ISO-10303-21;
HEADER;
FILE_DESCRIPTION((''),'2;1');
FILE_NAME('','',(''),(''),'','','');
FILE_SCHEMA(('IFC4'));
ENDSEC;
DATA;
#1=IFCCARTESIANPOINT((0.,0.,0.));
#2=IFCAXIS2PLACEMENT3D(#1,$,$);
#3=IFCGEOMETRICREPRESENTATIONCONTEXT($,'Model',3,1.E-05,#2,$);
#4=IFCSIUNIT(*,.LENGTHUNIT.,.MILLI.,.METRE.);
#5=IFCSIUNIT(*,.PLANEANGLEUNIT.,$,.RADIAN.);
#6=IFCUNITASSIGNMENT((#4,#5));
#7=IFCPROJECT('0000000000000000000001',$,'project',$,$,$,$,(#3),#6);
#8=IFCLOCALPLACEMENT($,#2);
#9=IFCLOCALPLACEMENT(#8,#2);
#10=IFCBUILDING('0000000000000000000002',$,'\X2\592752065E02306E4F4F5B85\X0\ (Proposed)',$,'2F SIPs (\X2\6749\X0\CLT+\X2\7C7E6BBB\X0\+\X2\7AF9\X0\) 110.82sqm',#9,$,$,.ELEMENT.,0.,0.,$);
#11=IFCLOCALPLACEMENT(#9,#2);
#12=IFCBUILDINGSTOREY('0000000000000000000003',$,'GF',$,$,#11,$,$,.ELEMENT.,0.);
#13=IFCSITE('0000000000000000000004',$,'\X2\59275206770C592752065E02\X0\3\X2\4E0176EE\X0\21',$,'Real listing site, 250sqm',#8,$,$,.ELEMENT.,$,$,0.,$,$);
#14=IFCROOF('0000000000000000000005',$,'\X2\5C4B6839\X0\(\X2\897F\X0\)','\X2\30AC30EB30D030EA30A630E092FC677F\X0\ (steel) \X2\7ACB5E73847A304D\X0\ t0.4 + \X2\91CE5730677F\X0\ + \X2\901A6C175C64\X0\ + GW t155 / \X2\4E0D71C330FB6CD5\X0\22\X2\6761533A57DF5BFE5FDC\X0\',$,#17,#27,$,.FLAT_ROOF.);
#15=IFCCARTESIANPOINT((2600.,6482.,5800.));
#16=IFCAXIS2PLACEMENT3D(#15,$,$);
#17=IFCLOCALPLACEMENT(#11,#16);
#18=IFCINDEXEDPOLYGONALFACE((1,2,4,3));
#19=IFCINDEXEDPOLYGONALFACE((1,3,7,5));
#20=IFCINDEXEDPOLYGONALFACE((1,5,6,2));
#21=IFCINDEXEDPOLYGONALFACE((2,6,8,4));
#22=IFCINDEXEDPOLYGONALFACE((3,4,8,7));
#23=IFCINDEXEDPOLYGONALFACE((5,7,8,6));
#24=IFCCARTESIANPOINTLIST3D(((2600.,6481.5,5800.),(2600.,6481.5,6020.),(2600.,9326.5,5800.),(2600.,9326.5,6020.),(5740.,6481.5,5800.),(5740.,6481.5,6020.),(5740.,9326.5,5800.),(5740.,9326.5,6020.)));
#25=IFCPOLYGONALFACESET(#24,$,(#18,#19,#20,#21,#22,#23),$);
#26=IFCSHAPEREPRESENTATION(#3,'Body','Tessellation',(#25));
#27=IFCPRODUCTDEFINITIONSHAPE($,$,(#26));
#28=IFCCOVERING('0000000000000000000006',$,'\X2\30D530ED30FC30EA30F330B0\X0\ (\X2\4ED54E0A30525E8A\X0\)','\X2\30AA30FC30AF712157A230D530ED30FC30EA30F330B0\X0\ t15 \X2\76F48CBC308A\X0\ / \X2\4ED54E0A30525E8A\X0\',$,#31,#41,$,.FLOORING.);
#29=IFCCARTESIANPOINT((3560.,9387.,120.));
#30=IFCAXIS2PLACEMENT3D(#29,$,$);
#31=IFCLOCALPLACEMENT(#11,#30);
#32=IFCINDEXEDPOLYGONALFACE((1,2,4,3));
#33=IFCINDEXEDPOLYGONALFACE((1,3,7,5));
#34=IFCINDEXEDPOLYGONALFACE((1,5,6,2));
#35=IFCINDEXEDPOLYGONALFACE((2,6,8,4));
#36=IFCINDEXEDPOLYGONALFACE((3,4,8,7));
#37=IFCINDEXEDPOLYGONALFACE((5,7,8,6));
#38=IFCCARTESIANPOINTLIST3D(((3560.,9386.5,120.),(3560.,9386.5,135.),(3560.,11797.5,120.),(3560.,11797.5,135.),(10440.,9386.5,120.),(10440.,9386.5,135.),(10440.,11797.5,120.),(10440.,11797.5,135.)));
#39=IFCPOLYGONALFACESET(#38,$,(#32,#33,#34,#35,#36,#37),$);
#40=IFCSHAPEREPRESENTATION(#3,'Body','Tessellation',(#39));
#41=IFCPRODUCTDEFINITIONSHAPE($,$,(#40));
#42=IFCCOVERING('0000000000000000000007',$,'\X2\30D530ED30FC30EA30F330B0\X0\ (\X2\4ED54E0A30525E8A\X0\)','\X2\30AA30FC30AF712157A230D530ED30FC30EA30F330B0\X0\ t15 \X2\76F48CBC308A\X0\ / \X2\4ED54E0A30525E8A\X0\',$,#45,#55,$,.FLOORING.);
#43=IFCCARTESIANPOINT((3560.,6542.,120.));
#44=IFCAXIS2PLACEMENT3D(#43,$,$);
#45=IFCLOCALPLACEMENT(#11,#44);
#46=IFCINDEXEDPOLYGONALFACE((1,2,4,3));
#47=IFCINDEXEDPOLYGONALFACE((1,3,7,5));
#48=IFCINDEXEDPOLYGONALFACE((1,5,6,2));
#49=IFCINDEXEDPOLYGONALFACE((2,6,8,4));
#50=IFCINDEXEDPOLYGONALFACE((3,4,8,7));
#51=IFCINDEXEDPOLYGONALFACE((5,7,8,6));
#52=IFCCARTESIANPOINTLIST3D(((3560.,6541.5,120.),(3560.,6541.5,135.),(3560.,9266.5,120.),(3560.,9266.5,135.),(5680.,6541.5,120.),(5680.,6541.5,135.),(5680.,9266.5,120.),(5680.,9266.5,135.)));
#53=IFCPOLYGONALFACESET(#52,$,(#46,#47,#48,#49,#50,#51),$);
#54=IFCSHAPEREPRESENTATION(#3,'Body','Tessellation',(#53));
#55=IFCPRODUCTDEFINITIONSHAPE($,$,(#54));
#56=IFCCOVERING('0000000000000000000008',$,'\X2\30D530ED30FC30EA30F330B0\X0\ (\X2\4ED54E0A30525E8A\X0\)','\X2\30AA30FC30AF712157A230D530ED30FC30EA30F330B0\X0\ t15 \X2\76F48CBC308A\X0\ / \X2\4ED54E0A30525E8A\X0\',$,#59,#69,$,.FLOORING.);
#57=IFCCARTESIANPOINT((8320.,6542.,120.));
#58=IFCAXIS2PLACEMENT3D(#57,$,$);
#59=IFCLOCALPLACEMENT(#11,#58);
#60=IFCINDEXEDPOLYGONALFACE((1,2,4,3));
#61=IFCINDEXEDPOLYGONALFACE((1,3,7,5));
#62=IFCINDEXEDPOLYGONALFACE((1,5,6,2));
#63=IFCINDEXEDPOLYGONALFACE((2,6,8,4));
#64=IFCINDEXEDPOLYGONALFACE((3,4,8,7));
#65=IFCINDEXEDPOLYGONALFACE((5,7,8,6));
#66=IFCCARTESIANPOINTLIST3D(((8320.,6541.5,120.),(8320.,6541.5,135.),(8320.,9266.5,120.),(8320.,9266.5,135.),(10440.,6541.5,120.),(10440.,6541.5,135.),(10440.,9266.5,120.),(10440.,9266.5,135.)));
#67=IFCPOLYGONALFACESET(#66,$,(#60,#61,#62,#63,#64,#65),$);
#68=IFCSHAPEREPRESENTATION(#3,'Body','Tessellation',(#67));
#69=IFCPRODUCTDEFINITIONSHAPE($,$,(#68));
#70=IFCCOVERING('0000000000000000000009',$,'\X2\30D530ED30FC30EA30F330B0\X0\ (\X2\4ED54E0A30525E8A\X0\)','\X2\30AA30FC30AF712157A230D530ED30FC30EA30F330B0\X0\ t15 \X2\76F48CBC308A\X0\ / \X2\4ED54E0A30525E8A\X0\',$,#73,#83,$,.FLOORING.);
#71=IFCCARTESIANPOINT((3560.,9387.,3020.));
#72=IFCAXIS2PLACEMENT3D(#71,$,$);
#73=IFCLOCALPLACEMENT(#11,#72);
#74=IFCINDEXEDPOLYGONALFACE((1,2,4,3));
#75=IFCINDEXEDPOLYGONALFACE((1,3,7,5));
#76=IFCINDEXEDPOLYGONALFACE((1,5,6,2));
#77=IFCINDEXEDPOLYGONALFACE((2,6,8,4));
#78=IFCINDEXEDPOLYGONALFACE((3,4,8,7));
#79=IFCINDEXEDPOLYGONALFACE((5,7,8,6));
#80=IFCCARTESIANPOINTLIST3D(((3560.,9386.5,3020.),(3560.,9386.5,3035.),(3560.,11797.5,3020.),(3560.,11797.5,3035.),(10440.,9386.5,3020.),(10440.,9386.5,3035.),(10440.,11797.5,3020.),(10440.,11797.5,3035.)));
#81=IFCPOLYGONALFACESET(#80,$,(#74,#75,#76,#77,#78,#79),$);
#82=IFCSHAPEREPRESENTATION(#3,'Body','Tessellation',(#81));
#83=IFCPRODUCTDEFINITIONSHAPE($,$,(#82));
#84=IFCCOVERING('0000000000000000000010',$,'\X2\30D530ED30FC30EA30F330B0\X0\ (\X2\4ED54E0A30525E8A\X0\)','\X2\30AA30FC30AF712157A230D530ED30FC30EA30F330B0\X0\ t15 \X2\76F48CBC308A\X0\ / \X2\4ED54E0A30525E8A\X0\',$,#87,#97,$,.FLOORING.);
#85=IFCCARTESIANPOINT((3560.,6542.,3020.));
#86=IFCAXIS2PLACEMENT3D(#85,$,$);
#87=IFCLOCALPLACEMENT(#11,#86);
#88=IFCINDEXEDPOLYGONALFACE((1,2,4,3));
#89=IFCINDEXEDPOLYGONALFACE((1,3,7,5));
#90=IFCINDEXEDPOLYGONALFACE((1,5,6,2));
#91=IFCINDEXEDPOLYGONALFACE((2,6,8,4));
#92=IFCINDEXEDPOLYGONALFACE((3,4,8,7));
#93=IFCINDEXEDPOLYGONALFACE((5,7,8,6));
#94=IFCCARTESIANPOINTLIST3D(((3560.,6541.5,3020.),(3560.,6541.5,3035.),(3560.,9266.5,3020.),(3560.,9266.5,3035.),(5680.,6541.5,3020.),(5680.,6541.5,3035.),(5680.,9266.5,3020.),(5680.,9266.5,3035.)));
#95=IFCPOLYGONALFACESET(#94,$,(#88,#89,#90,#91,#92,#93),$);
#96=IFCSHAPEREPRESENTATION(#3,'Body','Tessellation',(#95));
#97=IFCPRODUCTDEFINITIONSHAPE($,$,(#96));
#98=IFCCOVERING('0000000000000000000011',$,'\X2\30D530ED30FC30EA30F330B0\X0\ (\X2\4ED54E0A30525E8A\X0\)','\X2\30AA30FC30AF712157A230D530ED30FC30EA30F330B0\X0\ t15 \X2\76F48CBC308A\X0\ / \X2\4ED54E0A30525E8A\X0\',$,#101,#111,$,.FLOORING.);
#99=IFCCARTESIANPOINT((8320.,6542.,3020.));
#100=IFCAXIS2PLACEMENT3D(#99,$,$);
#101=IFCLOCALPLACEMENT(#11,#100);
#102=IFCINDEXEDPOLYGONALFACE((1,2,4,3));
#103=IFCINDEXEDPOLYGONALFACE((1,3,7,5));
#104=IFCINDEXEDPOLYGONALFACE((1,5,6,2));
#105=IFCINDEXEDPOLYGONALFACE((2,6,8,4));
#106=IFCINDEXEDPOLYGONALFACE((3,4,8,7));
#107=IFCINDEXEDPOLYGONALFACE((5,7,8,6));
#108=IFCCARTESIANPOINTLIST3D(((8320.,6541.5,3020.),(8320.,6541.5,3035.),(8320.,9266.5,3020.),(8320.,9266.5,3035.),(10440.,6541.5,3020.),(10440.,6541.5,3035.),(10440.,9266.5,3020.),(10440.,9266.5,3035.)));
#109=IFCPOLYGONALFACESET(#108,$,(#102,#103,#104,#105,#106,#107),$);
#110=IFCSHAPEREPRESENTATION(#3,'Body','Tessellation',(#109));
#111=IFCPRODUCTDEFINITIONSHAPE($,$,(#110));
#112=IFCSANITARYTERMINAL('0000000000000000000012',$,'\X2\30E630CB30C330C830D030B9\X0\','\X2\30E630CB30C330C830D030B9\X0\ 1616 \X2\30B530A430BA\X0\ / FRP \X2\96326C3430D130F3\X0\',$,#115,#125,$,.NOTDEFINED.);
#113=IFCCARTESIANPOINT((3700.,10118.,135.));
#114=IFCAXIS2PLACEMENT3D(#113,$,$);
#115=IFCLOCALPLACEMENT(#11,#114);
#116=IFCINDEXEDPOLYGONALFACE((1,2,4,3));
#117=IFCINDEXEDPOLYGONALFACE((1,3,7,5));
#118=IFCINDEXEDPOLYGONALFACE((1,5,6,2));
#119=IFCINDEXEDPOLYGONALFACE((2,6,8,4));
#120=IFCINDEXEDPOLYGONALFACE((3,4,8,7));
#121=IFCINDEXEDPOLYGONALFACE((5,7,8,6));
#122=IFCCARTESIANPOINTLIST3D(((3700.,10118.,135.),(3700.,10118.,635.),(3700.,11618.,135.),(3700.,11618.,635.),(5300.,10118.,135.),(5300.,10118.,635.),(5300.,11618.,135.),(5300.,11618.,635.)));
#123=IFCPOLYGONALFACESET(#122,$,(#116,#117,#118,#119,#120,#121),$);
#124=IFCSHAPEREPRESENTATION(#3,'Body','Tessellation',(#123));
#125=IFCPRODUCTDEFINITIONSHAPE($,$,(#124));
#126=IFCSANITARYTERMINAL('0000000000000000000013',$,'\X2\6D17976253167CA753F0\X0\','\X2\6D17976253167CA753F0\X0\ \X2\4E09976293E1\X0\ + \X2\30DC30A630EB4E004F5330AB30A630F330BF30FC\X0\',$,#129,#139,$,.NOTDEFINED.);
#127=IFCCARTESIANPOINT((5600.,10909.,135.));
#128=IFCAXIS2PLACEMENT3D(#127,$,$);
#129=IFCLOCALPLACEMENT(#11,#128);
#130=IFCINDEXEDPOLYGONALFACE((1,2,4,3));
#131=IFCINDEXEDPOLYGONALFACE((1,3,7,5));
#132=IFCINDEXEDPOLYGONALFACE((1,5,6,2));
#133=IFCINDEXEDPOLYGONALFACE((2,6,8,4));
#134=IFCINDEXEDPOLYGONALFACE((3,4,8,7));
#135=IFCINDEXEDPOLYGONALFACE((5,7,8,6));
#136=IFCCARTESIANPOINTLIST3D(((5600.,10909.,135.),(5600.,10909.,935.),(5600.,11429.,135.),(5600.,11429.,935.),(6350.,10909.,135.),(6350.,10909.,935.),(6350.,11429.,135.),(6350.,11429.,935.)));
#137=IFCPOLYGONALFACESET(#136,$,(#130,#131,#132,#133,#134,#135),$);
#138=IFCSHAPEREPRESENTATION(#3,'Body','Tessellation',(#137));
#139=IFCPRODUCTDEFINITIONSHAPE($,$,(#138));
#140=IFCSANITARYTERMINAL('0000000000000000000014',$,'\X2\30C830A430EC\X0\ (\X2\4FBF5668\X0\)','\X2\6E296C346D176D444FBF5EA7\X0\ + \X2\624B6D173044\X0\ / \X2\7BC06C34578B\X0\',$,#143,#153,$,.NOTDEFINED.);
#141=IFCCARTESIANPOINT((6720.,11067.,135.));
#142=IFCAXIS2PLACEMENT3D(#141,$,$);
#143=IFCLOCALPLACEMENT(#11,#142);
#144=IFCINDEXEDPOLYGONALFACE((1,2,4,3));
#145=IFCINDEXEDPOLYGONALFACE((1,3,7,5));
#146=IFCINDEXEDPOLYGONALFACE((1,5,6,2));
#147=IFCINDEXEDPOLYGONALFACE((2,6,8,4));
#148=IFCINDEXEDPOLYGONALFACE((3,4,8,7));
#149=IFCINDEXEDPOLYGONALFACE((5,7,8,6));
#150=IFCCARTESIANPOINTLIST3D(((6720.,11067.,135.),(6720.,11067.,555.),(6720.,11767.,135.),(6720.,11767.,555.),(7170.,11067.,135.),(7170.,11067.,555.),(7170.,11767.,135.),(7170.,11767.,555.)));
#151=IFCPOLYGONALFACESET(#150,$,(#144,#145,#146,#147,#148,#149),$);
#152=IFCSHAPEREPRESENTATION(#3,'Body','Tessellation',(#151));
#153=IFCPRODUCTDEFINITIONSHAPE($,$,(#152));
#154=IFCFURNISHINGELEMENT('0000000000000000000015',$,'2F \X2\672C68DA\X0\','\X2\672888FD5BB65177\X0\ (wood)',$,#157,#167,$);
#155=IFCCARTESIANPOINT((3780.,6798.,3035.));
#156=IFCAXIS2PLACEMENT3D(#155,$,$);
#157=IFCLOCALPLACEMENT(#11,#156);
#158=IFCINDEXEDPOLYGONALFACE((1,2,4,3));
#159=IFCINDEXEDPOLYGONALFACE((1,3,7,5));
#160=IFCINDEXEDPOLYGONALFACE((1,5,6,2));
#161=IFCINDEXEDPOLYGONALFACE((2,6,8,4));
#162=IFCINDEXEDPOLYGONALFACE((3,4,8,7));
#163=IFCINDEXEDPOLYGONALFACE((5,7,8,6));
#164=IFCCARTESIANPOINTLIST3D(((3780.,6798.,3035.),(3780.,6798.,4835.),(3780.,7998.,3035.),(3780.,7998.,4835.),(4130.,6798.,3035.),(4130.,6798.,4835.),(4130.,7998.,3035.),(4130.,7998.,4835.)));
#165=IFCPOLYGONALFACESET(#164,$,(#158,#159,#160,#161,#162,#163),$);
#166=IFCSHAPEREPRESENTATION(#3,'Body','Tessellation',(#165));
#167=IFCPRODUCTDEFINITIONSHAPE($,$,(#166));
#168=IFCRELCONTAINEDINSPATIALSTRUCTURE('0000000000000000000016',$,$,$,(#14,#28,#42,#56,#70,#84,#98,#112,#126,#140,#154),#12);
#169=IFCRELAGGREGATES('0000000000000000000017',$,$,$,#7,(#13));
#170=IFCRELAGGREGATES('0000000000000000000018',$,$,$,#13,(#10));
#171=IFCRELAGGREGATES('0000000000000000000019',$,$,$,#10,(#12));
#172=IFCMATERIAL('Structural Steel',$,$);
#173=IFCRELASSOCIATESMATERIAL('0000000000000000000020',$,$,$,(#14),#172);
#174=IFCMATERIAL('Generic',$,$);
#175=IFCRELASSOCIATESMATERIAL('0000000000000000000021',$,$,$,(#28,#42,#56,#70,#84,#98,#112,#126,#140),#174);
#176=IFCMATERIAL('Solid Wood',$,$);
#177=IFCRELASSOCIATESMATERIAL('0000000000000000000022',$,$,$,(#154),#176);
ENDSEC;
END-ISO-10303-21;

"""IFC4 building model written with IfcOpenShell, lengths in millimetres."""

from ifc_helpers import new_model, si_unit, frame, frame_2d, origin, place, context, project, spatial, rectangle, extrude, material, element, save


model = new_model("IFC4")

# Units and contexts
model_context = context("Model", 3, precision=1e-05, world=origin())
ifc_project = project(units=[si_unit("LENGTHUNIT", "METRE", prefix="MILLI"), si_unit("PLANEANGLEUNIT", "RADIAN")], contexts=[model_context])

# Site, building, storey
site_placement = place(None, origin())
site = spatial("IfcSite", under=ifc_project, at=site_placement, Name="大分県大分市3丁目21", ObjectType="Real listing site, 250sqm", CompositionType="ELEMENT", RefElevation=0.0)
building_placement = place(site_placement, origin())
building = spatial("IfcBuilding", under=site, at=building_placement, Name="大分市の住宅 (Proposed)", ObjectType="2F SIPs (杉CLT+籾殻+竹) 110.82sqm", CompositionType="ELEMENT", ElevationOfRefHeight=0.0, ElevationOfTerrain=0.0)
storey_placement = place(building_placement, origin())
storey = spatial("IfcBuildingStorey", under=building, at=storey_placement, Name="GF", CompositionType="ELEMENT", Elevation=0.0)

# Shared definitions
ifc_material_1 = material(Name="Solid Wood")

# Shared definitions
ifc_material_2 = material(Name="Generic")

# Roof
ifc_material_3 = material(Name="Structural Steel")
roof_1_placement = place(storey_placement, frame((2600.0, 6482.0, 5800.0)))
element("IfcRoof", 1, at=roof_1_placement, inside=storey, material=ifc_material_3, Name="屋根(西)", Description="ガルバリウム鋼板 (steel) 立平葺き t0.4 + 野地板 + 通気層 + GW t155 / 不燃・法22条区域対応", PredefinedType="FLAT_ROOF", context=model_context, shape_type="SweptSolid", body=[
    extrude(rectangle(XDim=3140.0, YDim=2845.0, at=frame_2d((1570.0, 1422.0))), frame((2600.0, 6482.0, 5800.0)), (0.0, 0.0, 1.0), 220.0),
])

# Coverings
covering_1_placement = place(storey_placement, frame((3560.0, 9387.0, 120.0)))
element("IfcCovering", 2, at=covering_1_placement, inside=storey, material=ifc_material_2, Name="フローリング (仕上げ床)", Description="オーク無垢フローリング t15 直貼り / 仕上げ床", PredefinedType="FLOORING", context=model_context, shape_type="SweptSolid", body=[
    extrude(rectangle(XDim=6880.0, YDim=2411.0, at=frame_2d((3440.0, 1205.0))), frame((3560.0, 9387.0, 120.0)), (0.0, 0.0, 1.0), 15.0),
])
covering_2_placement = place(storey_placement, frame((3560.0, 6542.0, 120.0)))
element("IfcCovering", 3, at=covering_2_placement, inside=storey, material=ifc_material_2, Name="フローリング (仕上げ床)", Description="オーク無垢フローリング t15 直貼り / 仕上げ床", PredefinedType="FLOORING", context=model_context, shape_type="SweptSolid", body=[
    extrude(rectangle(XDim=2120.0, YDim=2725.0, at=frame_2d((1060.0, 1362.0))), frame((3560.0, 6542.0, 120.0)), (0.0, 0.0, 1.0), 15.0),
])
covering_3_placement = place(storey_placement, frame((8320.0, 6542.0, 120.0)))
element("IfcCovering", 4, at=covering_3_placement, inside=storey, material=ifc_material_2, Name="フローリング (仕上げ床)", Description="オーク無垢フローリング t15 直貼り / 仕上げ床", PredefinedType="FLOORING", context=model_context, shape_type="SweptSolid", body=[
    extrude(rectangle(XDim=2120.0, YDim=2725.0, at=frame_2d((1060.0, 1362.0))), frame((8320.0, 6542.0, 120.0)), (0.0, 0.0, 1.0), 15.0),
])
covering_4_placement = place(storey_placement, frame((3560.0, 9387.0, 3020.0)))
element("IfcCovering", 5, at=covering_4_placement, inside=storey, material=ifc_material_2, Name="フローリング (仕上げ床)", Description="オーク無垢フローリング t15 直貼り / 仕上げ床", PredefinedType="FLOORING", context=model_context, shape_type="SweptSolid", body=[
    extrude(rectangle(XDim=6880.0, YDim=2411.0, at=frame_2d((3440.0, 1205.0))), frame((3560.0, 9387.0, 3020.0)), (0.0, 0.0, 1.0), 15.0),
])
covering_5_placement = place(storey_placement, frame((3560.0, 6542.0, 3020.0)))
element("IfcCovering", 6, at=covering_5_placement, inside=storey, material=ifc_material_2, Name="フローリング (仕上げ床)", Description="オーク無垢フローリング t15 直貼り / 仕上げ床", PredefinedType="FLOORING", context=model_context, shape_type="SweptSolid", body=[
    extrude(rectangle(XDim=2120.0, YDim=2725.0, at=frame_2d((1060.0, 1362.0))), frame((3560.0, 6542.0, 3020.0)), (0.0, 0.0, 1.0), 15.0),
])
covering_6_placement = place(storey_placement, frame((8320.0, 6542.0, 3020.0)))
element("IfcCovering", 7, at=covering_6_placement, inside=storey, material=ifc_material_2, Name="フローリング (仕上げ床)", Description="オーク無垢フローリング t15 直貼り / 仕上げ床", PredefinedType="FLOORING", context=model_context, shape_type="SweptSolid", body=[
    extrude(rectangle(XDim=2120.0, YDim=2725.0, at=frame_2d((1060.0, 1362.0))), frame((8320.0, 6542.0, 3020.0)), (0.0, 0.0, 1.0), 15.0),
])

# Sanitary terminals
sanitary_terminal_1_placement = place(storey_placement, frame((3700.0, 10118.0, 135.0)))
element("IfcSanitaryTerminal", 8, at=sanitary_terminal_1_placement, inside=storey, material=ifc_material_2, Name="ユニットバス", Description="ユニットバス 1616 サイズ / FRP 防水パン", PredefinedType="NOTDEFINED", context=model_context, shape_type="SweptSolid", body=[
    extrude(rectangle(XDim=1600.0, YDim=1500.0, at=frame_2d((800.0, 750.0))), frame((3700.0, 10118.0, 135.0)), (0.0, 0.0, 1.0), 500.0),
])
sanitary_terminal_2_placement = place(storey_placement, frame((5600.0, 10909.0, 135.0)))
element("IfcSanitaryTerminal", 9, at=sanitary_terminal_2_placement, inside=storey, material=ifc_material_2, Name="洗面化粧台", Description="洗面化粧台 三面鏡 + ボウル一体カウンター", PredefinedType="NOTDEFINED", context=model_context, shape_type="SweptSolid", body=[
    extrude(rectangle(XDim=750.0, YDim=520.0, at=frame_2d((375.0, 260.0))), frame((5600.0, 10909.0, 135.0)), (0.0, 0.0, 1.0), 800.0),
])
sanitary_terminal_3_placement = place(storey_placement, frame((6720.0, 11067.0, 135.0)))
element("IfcSanitaryTerminal", 10, at=sanitary_terminal_3_placement, inside=storey, material=ifc_material_2, Name="トイレ (便器)", Description="温水洗浄便座 + 手洗い / 節水型", PredefinedType="NOTDEFINED", context=model_context, shape_type="SweptSolid", body=[
    extrude(rectangle(XDim=450.0, YDim=700.0, at=frame_2d((225.0, 350.0))), frame((6720.0, 11067.0, 135.0)), (0.0, 0.0, 1.0), 420.0),
])

# Furnishing element
furnishing_placement = place(storey_placement, frame((3780.0, 6798.0, 3035.0)))
element("IfcFurnishingElement", 11, at=furnishing_placement, inside=storey, material=ifc_material_1, Name="2F 本棚", Description="木製家具 (wood)", context=model_context, shape_type="SweptSolid", body=[
    extrude(rectangle(XDim=350.0, YDim=1200.0, at=frame_2d((175.0, 600.0))), frame((3780.0, 6798.0, 3035.0)), (0.0, 0.0, 1.0), 1800.0),
])

save(model, "model.ifc")
